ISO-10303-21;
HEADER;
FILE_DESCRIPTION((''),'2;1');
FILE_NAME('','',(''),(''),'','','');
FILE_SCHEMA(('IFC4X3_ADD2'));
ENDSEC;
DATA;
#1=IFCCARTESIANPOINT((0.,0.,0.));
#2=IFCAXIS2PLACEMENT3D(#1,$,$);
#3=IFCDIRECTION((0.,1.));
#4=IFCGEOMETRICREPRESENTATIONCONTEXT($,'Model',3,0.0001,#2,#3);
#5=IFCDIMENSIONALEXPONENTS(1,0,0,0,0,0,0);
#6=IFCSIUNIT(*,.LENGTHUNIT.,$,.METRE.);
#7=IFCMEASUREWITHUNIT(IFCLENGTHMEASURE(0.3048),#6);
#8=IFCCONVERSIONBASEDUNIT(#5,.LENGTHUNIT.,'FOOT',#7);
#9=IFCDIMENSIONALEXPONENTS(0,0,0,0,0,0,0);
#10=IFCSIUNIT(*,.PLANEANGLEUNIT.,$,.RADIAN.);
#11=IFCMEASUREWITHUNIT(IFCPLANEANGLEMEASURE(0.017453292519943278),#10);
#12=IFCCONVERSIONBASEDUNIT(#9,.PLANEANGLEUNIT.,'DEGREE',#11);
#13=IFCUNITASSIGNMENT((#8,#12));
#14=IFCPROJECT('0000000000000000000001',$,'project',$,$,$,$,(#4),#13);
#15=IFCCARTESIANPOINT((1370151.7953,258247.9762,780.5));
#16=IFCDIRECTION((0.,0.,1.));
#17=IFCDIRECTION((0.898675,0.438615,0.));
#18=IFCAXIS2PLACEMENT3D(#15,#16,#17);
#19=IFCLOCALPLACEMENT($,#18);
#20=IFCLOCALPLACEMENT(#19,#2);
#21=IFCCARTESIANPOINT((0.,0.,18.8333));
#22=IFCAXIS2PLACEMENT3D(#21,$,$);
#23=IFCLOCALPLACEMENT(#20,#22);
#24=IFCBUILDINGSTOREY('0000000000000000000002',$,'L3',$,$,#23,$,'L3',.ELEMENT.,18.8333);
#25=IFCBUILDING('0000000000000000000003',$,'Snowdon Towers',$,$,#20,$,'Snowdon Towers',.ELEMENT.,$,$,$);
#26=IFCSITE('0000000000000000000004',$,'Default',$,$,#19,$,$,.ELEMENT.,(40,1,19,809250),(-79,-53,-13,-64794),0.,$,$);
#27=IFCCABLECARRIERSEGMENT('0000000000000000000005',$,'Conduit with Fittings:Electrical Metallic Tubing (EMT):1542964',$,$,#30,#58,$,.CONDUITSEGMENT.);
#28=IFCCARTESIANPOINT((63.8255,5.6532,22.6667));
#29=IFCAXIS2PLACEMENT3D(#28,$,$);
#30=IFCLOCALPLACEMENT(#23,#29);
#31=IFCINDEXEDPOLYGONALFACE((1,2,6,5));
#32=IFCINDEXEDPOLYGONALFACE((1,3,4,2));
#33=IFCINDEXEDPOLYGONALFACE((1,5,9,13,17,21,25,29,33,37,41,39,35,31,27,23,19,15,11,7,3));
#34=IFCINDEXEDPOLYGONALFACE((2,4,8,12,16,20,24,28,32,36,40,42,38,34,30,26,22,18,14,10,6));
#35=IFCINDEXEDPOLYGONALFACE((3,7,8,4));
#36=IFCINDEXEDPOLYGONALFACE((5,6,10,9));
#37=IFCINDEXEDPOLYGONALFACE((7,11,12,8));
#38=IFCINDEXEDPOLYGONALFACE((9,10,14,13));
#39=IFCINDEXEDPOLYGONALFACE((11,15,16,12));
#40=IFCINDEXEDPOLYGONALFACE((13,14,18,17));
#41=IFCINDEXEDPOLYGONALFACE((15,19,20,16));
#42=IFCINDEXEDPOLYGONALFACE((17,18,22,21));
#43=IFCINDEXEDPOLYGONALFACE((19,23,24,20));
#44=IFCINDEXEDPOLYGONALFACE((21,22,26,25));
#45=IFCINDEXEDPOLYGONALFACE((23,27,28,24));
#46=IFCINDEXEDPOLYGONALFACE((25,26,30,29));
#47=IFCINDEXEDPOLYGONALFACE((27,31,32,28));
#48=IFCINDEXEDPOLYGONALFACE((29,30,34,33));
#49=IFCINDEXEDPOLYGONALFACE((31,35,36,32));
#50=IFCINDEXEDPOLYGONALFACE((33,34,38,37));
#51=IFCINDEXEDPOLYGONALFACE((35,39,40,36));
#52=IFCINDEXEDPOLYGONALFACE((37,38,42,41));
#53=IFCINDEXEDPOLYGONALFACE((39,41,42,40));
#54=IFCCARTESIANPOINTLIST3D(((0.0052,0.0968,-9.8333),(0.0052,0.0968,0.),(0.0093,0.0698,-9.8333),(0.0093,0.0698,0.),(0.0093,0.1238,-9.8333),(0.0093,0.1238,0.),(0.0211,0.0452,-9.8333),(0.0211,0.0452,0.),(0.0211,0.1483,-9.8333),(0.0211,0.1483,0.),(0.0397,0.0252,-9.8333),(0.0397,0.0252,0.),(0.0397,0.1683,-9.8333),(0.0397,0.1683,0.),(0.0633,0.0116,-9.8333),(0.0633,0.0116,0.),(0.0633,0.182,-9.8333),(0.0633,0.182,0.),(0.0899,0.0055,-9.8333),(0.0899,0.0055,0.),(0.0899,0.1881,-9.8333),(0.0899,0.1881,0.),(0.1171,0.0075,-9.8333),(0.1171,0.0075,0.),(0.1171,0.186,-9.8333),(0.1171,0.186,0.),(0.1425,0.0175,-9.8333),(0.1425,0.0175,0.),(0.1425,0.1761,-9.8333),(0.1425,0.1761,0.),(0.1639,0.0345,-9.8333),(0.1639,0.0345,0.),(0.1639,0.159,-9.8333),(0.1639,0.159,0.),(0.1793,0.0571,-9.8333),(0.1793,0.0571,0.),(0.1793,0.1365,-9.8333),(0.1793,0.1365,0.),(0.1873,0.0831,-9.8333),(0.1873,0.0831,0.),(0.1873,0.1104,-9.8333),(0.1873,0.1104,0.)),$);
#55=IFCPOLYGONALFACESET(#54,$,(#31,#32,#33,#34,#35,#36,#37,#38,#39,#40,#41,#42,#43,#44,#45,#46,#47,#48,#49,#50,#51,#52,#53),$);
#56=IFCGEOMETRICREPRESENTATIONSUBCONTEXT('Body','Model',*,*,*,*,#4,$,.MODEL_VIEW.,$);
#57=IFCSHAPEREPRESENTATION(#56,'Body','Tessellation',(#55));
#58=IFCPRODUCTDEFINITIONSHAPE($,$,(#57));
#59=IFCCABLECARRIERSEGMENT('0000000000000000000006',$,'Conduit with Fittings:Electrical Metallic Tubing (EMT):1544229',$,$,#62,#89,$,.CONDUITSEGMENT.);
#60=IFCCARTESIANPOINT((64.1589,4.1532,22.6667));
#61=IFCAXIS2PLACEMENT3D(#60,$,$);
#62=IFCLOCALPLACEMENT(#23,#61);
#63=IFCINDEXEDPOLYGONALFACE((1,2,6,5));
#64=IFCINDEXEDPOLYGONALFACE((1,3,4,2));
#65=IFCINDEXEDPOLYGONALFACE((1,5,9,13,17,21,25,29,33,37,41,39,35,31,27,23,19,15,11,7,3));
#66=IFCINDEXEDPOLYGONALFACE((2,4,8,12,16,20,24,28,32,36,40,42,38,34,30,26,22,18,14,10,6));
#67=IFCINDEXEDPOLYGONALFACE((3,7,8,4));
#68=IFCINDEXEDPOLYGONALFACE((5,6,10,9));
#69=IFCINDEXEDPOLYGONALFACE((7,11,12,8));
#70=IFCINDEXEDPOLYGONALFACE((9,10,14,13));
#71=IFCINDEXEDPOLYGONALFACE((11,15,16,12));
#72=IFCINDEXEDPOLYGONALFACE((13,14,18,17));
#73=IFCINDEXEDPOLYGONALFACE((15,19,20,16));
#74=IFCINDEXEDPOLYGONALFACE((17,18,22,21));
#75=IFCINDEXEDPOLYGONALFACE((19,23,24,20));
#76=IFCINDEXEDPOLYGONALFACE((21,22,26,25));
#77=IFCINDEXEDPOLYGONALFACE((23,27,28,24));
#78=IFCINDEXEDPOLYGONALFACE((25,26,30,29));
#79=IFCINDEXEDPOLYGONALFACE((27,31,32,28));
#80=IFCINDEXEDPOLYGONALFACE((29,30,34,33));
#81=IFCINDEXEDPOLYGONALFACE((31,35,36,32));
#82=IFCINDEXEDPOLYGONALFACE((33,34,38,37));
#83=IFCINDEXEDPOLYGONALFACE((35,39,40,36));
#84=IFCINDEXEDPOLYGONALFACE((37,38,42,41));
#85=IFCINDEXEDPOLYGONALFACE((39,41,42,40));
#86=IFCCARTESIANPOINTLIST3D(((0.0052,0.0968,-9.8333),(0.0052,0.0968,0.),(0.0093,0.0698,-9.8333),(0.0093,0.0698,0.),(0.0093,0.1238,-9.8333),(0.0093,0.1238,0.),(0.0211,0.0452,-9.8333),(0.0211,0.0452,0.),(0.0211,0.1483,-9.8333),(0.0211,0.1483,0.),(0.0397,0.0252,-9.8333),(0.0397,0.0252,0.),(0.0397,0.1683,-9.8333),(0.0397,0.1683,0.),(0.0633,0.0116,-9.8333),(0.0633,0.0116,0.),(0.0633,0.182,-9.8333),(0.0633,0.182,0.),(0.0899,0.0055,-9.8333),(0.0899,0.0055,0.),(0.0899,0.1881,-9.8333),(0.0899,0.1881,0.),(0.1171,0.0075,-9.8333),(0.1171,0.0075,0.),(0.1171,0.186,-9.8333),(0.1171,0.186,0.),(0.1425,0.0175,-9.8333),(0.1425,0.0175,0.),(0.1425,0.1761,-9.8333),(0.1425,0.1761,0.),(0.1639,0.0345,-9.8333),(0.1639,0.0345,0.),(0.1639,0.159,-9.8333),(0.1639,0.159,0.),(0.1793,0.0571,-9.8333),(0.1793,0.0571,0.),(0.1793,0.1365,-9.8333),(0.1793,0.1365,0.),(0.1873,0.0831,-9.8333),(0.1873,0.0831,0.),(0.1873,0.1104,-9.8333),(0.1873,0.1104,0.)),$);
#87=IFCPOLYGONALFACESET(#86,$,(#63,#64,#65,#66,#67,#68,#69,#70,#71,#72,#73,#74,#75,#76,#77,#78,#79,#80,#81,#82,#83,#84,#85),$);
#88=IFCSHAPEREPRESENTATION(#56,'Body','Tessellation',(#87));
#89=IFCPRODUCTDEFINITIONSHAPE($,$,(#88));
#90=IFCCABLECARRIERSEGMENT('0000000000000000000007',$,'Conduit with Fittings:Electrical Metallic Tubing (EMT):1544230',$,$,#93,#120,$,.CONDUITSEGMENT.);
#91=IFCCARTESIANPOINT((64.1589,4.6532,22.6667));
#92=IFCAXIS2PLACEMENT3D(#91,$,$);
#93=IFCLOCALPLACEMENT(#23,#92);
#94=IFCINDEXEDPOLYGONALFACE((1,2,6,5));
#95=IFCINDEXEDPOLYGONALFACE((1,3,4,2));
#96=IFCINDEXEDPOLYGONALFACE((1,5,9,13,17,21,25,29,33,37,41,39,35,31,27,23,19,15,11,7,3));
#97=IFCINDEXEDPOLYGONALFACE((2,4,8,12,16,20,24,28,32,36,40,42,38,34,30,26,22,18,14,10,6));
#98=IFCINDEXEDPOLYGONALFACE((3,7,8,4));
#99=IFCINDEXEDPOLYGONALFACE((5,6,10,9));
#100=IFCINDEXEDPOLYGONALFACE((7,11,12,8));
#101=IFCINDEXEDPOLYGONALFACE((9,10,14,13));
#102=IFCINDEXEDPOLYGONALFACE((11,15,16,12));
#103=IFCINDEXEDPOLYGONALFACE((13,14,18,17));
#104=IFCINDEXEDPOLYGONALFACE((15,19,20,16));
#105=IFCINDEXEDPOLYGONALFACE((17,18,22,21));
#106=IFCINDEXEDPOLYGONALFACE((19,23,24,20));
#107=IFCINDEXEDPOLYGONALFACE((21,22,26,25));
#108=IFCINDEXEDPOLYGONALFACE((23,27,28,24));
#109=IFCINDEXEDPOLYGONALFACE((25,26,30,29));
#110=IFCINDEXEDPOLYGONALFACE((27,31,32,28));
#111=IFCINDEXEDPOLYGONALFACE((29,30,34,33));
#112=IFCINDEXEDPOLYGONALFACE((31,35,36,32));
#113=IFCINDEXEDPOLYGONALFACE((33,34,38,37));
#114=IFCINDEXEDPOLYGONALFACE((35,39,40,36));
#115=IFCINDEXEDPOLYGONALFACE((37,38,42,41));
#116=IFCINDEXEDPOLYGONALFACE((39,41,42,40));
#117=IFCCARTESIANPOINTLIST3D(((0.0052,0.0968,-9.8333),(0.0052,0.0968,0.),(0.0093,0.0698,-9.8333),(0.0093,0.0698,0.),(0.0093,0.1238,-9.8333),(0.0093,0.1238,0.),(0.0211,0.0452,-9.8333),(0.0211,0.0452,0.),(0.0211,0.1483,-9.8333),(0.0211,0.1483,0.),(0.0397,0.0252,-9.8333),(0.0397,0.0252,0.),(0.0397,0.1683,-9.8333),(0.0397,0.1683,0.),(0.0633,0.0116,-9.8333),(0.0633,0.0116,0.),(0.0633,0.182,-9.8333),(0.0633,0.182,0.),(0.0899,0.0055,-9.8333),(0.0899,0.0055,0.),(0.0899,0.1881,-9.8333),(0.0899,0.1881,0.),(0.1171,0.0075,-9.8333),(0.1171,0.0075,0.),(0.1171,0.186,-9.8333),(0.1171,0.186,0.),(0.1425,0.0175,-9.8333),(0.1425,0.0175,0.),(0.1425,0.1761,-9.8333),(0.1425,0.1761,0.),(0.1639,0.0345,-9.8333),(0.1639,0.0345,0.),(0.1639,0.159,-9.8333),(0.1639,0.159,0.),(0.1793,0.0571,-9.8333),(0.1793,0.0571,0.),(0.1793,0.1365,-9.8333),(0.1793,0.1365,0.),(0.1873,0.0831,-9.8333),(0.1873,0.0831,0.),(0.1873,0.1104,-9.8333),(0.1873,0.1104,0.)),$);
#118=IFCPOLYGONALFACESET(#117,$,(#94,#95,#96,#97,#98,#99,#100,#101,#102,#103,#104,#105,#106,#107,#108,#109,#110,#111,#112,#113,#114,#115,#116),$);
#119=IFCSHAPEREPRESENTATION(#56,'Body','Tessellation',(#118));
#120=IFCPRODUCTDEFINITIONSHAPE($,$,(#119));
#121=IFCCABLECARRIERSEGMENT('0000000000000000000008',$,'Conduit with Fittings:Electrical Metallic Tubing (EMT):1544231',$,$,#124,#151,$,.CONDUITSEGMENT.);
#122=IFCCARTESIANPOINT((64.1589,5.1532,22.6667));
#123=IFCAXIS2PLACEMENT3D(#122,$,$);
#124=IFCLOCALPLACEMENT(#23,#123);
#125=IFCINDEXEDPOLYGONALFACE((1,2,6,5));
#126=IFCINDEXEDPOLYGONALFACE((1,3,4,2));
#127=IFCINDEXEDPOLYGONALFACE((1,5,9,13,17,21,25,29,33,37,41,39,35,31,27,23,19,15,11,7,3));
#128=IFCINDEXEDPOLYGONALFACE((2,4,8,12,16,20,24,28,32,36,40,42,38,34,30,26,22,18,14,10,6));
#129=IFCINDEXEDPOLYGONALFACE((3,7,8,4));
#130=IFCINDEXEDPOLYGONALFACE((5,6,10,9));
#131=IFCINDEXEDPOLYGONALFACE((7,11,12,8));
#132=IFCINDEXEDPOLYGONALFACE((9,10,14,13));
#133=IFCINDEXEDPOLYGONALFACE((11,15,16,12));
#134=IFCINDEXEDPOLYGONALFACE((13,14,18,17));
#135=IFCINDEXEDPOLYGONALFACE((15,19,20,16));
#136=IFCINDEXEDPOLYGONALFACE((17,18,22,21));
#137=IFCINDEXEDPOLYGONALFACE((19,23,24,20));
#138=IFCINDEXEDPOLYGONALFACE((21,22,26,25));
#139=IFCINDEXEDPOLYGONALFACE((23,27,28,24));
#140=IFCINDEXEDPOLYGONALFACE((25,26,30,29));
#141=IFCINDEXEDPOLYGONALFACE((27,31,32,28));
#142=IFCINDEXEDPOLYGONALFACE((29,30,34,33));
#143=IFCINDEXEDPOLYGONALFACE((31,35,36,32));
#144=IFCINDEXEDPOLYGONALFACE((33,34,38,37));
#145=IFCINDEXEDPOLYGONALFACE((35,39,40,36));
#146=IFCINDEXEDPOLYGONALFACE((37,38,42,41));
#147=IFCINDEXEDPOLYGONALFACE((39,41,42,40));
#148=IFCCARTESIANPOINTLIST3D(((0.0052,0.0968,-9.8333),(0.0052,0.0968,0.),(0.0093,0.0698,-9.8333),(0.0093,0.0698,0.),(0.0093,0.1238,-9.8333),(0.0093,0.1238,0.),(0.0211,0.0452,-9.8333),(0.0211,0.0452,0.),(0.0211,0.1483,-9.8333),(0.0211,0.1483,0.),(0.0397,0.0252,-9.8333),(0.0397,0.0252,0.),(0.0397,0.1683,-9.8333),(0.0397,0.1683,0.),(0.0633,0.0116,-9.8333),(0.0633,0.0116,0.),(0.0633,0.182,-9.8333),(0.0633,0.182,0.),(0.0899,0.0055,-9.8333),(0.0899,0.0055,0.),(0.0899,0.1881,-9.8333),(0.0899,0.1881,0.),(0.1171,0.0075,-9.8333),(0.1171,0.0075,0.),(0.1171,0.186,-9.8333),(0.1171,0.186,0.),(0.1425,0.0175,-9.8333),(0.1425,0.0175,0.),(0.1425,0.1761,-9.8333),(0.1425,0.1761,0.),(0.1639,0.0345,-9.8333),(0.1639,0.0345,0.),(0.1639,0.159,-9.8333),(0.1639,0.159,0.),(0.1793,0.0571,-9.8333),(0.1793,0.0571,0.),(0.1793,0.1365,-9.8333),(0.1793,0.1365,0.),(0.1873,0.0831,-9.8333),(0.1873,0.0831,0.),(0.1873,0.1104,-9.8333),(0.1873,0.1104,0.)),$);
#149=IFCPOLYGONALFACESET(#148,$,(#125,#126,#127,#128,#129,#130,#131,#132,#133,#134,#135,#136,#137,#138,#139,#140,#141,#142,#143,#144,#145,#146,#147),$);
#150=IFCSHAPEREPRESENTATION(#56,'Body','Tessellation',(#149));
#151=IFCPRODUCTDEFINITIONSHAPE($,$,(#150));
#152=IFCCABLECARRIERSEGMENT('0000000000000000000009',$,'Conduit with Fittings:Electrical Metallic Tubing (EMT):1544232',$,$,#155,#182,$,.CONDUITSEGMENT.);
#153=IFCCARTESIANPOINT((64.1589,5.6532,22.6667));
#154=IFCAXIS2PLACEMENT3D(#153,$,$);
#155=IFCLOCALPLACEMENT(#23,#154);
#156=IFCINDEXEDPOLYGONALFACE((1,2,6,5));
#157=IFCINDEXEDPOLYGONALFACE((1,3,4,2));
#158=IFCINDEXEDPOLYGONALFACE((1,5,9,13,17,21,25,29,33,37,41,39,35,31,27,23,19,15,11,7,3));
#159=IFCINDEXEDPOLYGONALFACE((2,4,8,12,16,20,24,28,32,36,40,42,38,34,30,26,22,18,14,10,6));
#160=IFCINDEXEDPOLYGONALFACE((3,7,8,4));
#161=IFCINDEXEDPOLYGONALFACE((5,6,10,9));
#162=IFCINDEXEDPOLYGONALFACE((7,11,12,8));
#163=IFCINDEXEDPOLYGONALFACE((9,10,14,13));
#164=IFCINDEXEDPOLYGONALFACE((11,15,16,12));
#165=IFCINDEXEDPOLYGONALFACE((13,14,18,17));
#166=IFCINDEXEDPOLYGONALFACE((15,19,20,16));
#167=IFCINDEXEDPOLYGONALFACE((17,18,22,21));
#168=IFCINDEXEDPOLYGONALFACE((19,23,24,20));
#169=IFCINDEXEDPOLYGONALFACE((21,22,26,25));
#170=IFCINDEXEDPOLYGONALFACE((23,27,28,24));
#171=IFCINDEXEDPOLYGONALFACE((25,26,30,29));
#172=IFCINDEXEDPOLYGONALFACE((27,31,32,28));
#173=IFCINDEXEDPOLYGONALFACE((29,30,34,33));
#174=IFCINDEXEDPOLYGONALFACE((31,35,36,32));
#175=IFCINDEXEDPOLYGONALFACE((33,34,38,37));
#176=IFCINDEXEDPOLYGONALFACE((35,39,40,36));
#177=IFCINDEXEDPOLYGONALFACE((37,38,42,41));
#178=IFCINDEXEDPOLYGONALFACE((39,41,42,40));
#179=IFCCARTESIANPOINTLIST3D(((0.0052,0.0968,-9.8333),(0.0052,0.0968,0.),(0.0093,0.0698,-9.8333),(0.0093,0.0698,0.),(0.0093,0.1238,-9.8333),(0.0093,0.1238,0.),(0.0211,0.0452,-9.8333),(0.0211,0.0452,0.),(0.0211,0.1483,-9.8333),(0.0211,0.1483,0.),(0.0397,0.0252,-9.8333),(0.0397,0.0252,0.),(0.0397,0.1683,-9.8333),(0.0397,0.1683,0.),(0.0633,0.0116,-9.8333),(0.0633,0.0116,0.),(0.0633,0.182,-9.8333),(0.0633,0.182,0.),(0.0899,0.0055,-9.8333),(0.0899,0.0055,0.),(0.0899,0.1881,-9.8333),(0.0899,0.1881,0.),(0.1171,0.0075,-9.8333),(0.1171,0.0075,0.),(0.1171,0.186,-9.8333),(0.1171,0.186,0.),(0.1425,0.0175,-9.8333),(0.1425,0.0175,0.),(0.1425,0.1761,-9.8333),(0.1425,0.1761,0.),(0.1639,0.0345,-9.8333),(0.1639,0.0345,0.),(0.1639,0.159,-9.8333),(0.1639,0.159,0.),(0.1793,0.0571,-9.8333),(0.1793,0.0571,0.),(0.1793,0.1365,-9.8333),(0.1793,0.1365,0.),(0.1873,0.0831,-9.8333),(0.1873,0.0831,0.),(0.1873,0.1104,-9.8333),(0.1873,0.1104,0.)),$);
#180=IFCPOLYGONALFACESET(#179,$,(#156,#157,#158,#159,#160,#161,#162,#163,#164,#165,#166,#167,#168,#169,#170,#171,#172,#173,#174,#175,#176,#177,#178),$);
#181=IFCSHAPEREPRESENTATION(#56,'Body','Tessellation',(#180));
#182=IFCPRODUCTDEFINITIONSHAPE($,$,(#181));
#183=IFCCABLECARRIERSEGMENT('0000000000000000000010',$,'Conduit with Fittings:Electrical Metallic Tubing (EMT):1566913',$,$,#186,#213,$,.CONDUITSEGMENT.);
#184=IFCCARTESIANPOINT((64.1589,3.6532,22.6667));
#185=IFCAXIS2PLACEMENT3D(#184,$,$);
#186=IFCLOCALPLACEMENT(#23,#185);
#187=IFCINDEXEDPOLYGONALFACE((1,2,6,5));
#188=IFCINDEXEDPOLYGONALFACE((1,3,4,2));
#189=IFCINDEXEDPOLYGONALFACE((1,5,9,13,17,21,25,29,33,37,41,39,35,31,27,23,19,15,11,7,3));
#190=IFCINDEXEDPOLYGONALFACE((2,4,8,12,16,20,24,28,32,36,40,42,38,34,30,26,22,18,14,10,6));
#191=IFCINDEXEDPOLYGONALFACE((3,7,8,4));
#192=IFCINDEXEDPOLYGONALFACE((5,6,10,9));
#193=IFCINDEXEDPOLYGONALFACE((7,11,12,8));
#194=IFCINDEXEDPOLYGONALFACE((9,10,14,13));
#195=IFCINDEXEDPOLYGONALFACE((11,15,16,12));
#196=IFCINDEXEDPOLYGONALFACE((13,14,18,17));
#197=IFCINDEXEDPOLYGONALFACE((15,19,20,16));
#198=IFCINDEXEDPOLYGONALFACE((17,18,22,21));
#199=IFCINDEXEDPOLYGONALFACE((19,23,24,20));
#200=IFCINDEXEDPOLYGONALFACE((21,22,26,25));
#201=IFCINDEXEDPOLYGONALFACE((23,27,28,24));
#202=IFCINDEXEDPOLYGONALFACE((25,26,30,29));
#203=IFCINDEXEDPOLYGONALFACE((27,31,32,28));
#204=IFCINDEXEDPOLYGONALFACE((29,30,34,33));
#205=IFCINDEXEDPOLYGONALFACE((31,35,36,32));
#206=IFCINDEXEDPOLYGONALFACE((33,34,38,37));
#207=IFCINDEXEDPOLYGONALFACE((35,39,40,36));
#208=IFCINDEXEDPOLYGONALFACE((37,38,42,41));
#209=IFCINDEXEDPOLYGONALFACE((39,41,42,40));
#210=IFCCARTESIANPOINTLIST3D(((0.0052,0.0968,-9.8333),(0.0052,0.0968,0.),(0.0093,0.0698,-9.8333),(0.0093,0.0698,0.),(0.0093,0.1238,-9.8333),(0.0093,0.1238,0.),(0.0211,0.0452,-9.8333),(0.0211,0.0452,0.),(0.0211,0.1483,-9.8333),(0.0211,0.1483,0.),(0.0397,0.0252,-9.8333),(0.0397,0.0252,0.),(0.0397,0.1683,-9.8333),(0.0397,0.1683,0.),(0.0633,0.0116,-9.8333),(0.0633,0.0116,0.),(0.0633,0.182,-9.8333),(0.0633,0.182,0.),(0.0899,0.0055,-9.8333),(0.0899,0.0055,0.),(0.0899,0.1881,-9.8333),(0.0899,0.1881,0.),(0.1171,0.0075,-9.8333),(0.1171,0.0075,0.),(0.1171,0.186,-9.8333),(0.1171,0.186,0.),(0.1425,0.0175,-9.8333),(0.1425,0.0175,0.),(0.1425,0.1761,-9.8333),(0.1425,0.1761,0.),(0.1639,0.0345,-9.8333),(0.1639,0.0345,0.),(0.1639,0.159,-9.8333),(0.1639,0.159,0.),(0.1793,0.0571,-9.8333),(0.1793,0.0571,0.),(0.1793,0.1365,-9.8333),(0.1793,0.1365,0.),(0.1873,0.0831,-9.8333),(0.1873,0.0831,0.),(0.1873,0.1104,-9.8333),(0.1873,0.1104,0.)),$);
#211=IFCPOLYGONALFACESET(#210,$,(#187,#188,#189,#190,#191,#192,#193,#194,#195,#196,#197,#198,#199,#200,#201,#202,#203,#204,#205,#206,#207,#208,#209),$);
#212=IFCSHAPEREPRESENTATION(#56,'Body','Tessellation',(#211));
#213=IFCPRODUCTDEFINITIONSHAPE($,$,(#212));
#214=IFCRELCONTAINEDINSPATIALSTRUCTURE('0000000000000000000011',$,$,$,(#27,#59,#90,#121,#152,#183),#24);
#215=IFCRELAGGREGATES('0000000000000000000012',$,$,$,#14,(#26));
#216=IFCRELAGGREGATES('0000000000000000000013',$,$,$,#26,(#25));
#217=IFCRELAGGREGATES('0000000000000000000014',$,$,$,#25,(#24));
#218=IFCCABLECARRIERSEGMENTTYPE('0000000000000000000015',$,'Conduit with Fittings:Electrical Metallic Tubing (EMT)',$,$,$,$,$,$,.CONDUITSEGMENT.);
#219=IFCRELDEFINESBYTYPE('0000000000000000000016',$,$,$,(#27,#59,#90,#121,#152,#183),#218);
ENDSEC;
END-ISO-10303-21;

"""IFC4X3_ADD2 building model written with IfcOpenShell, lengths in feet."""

from ifc_helpers import new_model, entity, si_unit, converted_unit, direction, frame, frame_2d, origin, place, context, subcontext, project, spatial, circle, extrude, type_object, element, save


model = new_model("IFC4X3_ADD2")

# Units and contexts
model_context = context("Model", 3, precision=0.0001, world=origin(), true_north=direction((0.0, 1.0)))
body_context = subcontext(model_context, "Body", "Model", "MODEL_VIEW")
ifc_project = project(units=[converted_unit("LENGTHUNIT", "FOOT", entity("IfcLengthMeasure", 0.3048), si_unit("LENGTHUNIT", "METRE"), dimensions=[1, 0, 0, 0, 0, 0, 0]), converted_unit("PLANEANGLEUNIT", "DEGREE", entity("IfcPlaneAngleMeasure", 0.017453292519943278), si_unit("PLANEANGLEUNIT", "RADIAN"), dimensions=[0, 0, 0, 0, 0, 0, 0])], contexts=[model_context])

# Site, building, storey
site_placement = place(None, frame((1370151.7953, 258247.9762, 780.5), z_axis=(0.0, 0.0, 1.0), x_axis=(0.898675, 0.438615, 0.0)))
site = spatial("IfcSite", under=ifc_project, at=site_placement, Name="Default", CompositionType="ELEMENT", RefLatitude=(40, 1, 19, 809250), RefLongitude=(-79, -53, -13, -64794), RefElevation=0.0)
building_placement = place(site_placement, origin())
building = spatial("IfcBuilding", under=site, at=building_placement, Name="Snowdon Towers", LongName="Snowdon Towers", CompositionType="ELEMENT")
storey_placement = place(building_placement, frame((0.0, 0.0, 18.8333)))
storey = spatial("IfcBuildingStorey", under=building, at=storey_placement, Name="L3", LongName="L3", CompositionType="ELEMENT", Elevation=18.8333)

# Cable carrier segments
cable_carrier_segment_type = type_object("IfcCableCarrierSegmentType", Name="Conduit with Fittings:Electrical Metallic Tubing (EMT)", PredefinedType="CONDUITSEGMENT")
cable_carrier_segment_1_placement = place(storey_placement, frame((63.8255, 5.6532, 22.6667)))
element("IfcCableCarrierSegment", 1, at=cable_carrier_segment_1_placement, inside=storey, type_object=cable_carrier_segment_type, Name="Conduit with Fittings:Electrical Metallic Tubing (EMT):1542964", PredefinedType="CONDUITSEGMENT", context=body_context, shape_type="SweptSolid", body=[
    extrude(circle(Radius=0.0915, at=frame_2d((0.0, 0.0), x_axis=(1.0, 0.0))), frame((0.0968, 0.0968, -9.8333), z_axis=(0.0, 0.0, 1.0), x_axis=(-1.0, 0.0, 0.0)), (0.0, 0.0, 1.0), 9.8333),
])
for number, where, name in (
    (2, (64.1589, 4.1532, 22.6667), "Conduit with Fittings:Electrical Metallic Tubing (EMT):1544229"),
    (3, (64.1589, 4.6532, 22.6667), "Conduit with Fittings:Electrical Metallic Tubing (EMT):1544230"),
    (4, (64.1589, 5.1532, 22.6667), "Conduit with Fittings:Electrical Metallic Tubing (EMT):1544231"),
    (5, (64.1589, 5.6532, 22.6667), "Conduit with Fittings:Electrical Metallic Tubing (EMT):1544232"),
):
    element("IfcCableCarrierSegment", number, at=place(storey_placement, frame(where)), inside=storey, type_object=cable_carrier_segment_type, Name=name, PredefinedType="CONDUITSEGMENT", context=body_context, shape_type="SweptSolid", body=[
        extrude(circle(Radius=0.0915, at=frame_2d((0.0, 0.0), x_axis=(1.0, 0.0))), frame((0.0968, 0.0968, -9.8333), z_axis=(0.0, 0.0, 1.0), x_axis=(-1.0, 0.0, 0.0)), (0.0, 0.0, 1.0), 9.8333),
    ])
cable_carrier_segment_2_placement = place(storey_placement, frame((64.1589, 3.6532, 22.6667)))
element("IfcCableCarrierSegment", 6, at=cable_carrier_segment_2_placement, inside=storey, type_object=cable_carrier_segment_type, Name="Conduit with Fittings:Electrical Metallic Tubing (EMT):1566913", PredefinedType="CONDUITSEGMENT", context=body_context, shape_type="SweptSolid", body=[
    extrude(circle(Radius=0.0915, at=frame_2d((0.0, 0.0), x_axis=(1.0, 0.0))), frame((0.0968, 0.0968, -9.8333), z_axis=(0.0, 0.0, 1.0), x_axis=(-1.0, 0.0, 0.0)), (0.0, 0.0, 1.0), 9.8333),
])

save(model, "model.ifc")
